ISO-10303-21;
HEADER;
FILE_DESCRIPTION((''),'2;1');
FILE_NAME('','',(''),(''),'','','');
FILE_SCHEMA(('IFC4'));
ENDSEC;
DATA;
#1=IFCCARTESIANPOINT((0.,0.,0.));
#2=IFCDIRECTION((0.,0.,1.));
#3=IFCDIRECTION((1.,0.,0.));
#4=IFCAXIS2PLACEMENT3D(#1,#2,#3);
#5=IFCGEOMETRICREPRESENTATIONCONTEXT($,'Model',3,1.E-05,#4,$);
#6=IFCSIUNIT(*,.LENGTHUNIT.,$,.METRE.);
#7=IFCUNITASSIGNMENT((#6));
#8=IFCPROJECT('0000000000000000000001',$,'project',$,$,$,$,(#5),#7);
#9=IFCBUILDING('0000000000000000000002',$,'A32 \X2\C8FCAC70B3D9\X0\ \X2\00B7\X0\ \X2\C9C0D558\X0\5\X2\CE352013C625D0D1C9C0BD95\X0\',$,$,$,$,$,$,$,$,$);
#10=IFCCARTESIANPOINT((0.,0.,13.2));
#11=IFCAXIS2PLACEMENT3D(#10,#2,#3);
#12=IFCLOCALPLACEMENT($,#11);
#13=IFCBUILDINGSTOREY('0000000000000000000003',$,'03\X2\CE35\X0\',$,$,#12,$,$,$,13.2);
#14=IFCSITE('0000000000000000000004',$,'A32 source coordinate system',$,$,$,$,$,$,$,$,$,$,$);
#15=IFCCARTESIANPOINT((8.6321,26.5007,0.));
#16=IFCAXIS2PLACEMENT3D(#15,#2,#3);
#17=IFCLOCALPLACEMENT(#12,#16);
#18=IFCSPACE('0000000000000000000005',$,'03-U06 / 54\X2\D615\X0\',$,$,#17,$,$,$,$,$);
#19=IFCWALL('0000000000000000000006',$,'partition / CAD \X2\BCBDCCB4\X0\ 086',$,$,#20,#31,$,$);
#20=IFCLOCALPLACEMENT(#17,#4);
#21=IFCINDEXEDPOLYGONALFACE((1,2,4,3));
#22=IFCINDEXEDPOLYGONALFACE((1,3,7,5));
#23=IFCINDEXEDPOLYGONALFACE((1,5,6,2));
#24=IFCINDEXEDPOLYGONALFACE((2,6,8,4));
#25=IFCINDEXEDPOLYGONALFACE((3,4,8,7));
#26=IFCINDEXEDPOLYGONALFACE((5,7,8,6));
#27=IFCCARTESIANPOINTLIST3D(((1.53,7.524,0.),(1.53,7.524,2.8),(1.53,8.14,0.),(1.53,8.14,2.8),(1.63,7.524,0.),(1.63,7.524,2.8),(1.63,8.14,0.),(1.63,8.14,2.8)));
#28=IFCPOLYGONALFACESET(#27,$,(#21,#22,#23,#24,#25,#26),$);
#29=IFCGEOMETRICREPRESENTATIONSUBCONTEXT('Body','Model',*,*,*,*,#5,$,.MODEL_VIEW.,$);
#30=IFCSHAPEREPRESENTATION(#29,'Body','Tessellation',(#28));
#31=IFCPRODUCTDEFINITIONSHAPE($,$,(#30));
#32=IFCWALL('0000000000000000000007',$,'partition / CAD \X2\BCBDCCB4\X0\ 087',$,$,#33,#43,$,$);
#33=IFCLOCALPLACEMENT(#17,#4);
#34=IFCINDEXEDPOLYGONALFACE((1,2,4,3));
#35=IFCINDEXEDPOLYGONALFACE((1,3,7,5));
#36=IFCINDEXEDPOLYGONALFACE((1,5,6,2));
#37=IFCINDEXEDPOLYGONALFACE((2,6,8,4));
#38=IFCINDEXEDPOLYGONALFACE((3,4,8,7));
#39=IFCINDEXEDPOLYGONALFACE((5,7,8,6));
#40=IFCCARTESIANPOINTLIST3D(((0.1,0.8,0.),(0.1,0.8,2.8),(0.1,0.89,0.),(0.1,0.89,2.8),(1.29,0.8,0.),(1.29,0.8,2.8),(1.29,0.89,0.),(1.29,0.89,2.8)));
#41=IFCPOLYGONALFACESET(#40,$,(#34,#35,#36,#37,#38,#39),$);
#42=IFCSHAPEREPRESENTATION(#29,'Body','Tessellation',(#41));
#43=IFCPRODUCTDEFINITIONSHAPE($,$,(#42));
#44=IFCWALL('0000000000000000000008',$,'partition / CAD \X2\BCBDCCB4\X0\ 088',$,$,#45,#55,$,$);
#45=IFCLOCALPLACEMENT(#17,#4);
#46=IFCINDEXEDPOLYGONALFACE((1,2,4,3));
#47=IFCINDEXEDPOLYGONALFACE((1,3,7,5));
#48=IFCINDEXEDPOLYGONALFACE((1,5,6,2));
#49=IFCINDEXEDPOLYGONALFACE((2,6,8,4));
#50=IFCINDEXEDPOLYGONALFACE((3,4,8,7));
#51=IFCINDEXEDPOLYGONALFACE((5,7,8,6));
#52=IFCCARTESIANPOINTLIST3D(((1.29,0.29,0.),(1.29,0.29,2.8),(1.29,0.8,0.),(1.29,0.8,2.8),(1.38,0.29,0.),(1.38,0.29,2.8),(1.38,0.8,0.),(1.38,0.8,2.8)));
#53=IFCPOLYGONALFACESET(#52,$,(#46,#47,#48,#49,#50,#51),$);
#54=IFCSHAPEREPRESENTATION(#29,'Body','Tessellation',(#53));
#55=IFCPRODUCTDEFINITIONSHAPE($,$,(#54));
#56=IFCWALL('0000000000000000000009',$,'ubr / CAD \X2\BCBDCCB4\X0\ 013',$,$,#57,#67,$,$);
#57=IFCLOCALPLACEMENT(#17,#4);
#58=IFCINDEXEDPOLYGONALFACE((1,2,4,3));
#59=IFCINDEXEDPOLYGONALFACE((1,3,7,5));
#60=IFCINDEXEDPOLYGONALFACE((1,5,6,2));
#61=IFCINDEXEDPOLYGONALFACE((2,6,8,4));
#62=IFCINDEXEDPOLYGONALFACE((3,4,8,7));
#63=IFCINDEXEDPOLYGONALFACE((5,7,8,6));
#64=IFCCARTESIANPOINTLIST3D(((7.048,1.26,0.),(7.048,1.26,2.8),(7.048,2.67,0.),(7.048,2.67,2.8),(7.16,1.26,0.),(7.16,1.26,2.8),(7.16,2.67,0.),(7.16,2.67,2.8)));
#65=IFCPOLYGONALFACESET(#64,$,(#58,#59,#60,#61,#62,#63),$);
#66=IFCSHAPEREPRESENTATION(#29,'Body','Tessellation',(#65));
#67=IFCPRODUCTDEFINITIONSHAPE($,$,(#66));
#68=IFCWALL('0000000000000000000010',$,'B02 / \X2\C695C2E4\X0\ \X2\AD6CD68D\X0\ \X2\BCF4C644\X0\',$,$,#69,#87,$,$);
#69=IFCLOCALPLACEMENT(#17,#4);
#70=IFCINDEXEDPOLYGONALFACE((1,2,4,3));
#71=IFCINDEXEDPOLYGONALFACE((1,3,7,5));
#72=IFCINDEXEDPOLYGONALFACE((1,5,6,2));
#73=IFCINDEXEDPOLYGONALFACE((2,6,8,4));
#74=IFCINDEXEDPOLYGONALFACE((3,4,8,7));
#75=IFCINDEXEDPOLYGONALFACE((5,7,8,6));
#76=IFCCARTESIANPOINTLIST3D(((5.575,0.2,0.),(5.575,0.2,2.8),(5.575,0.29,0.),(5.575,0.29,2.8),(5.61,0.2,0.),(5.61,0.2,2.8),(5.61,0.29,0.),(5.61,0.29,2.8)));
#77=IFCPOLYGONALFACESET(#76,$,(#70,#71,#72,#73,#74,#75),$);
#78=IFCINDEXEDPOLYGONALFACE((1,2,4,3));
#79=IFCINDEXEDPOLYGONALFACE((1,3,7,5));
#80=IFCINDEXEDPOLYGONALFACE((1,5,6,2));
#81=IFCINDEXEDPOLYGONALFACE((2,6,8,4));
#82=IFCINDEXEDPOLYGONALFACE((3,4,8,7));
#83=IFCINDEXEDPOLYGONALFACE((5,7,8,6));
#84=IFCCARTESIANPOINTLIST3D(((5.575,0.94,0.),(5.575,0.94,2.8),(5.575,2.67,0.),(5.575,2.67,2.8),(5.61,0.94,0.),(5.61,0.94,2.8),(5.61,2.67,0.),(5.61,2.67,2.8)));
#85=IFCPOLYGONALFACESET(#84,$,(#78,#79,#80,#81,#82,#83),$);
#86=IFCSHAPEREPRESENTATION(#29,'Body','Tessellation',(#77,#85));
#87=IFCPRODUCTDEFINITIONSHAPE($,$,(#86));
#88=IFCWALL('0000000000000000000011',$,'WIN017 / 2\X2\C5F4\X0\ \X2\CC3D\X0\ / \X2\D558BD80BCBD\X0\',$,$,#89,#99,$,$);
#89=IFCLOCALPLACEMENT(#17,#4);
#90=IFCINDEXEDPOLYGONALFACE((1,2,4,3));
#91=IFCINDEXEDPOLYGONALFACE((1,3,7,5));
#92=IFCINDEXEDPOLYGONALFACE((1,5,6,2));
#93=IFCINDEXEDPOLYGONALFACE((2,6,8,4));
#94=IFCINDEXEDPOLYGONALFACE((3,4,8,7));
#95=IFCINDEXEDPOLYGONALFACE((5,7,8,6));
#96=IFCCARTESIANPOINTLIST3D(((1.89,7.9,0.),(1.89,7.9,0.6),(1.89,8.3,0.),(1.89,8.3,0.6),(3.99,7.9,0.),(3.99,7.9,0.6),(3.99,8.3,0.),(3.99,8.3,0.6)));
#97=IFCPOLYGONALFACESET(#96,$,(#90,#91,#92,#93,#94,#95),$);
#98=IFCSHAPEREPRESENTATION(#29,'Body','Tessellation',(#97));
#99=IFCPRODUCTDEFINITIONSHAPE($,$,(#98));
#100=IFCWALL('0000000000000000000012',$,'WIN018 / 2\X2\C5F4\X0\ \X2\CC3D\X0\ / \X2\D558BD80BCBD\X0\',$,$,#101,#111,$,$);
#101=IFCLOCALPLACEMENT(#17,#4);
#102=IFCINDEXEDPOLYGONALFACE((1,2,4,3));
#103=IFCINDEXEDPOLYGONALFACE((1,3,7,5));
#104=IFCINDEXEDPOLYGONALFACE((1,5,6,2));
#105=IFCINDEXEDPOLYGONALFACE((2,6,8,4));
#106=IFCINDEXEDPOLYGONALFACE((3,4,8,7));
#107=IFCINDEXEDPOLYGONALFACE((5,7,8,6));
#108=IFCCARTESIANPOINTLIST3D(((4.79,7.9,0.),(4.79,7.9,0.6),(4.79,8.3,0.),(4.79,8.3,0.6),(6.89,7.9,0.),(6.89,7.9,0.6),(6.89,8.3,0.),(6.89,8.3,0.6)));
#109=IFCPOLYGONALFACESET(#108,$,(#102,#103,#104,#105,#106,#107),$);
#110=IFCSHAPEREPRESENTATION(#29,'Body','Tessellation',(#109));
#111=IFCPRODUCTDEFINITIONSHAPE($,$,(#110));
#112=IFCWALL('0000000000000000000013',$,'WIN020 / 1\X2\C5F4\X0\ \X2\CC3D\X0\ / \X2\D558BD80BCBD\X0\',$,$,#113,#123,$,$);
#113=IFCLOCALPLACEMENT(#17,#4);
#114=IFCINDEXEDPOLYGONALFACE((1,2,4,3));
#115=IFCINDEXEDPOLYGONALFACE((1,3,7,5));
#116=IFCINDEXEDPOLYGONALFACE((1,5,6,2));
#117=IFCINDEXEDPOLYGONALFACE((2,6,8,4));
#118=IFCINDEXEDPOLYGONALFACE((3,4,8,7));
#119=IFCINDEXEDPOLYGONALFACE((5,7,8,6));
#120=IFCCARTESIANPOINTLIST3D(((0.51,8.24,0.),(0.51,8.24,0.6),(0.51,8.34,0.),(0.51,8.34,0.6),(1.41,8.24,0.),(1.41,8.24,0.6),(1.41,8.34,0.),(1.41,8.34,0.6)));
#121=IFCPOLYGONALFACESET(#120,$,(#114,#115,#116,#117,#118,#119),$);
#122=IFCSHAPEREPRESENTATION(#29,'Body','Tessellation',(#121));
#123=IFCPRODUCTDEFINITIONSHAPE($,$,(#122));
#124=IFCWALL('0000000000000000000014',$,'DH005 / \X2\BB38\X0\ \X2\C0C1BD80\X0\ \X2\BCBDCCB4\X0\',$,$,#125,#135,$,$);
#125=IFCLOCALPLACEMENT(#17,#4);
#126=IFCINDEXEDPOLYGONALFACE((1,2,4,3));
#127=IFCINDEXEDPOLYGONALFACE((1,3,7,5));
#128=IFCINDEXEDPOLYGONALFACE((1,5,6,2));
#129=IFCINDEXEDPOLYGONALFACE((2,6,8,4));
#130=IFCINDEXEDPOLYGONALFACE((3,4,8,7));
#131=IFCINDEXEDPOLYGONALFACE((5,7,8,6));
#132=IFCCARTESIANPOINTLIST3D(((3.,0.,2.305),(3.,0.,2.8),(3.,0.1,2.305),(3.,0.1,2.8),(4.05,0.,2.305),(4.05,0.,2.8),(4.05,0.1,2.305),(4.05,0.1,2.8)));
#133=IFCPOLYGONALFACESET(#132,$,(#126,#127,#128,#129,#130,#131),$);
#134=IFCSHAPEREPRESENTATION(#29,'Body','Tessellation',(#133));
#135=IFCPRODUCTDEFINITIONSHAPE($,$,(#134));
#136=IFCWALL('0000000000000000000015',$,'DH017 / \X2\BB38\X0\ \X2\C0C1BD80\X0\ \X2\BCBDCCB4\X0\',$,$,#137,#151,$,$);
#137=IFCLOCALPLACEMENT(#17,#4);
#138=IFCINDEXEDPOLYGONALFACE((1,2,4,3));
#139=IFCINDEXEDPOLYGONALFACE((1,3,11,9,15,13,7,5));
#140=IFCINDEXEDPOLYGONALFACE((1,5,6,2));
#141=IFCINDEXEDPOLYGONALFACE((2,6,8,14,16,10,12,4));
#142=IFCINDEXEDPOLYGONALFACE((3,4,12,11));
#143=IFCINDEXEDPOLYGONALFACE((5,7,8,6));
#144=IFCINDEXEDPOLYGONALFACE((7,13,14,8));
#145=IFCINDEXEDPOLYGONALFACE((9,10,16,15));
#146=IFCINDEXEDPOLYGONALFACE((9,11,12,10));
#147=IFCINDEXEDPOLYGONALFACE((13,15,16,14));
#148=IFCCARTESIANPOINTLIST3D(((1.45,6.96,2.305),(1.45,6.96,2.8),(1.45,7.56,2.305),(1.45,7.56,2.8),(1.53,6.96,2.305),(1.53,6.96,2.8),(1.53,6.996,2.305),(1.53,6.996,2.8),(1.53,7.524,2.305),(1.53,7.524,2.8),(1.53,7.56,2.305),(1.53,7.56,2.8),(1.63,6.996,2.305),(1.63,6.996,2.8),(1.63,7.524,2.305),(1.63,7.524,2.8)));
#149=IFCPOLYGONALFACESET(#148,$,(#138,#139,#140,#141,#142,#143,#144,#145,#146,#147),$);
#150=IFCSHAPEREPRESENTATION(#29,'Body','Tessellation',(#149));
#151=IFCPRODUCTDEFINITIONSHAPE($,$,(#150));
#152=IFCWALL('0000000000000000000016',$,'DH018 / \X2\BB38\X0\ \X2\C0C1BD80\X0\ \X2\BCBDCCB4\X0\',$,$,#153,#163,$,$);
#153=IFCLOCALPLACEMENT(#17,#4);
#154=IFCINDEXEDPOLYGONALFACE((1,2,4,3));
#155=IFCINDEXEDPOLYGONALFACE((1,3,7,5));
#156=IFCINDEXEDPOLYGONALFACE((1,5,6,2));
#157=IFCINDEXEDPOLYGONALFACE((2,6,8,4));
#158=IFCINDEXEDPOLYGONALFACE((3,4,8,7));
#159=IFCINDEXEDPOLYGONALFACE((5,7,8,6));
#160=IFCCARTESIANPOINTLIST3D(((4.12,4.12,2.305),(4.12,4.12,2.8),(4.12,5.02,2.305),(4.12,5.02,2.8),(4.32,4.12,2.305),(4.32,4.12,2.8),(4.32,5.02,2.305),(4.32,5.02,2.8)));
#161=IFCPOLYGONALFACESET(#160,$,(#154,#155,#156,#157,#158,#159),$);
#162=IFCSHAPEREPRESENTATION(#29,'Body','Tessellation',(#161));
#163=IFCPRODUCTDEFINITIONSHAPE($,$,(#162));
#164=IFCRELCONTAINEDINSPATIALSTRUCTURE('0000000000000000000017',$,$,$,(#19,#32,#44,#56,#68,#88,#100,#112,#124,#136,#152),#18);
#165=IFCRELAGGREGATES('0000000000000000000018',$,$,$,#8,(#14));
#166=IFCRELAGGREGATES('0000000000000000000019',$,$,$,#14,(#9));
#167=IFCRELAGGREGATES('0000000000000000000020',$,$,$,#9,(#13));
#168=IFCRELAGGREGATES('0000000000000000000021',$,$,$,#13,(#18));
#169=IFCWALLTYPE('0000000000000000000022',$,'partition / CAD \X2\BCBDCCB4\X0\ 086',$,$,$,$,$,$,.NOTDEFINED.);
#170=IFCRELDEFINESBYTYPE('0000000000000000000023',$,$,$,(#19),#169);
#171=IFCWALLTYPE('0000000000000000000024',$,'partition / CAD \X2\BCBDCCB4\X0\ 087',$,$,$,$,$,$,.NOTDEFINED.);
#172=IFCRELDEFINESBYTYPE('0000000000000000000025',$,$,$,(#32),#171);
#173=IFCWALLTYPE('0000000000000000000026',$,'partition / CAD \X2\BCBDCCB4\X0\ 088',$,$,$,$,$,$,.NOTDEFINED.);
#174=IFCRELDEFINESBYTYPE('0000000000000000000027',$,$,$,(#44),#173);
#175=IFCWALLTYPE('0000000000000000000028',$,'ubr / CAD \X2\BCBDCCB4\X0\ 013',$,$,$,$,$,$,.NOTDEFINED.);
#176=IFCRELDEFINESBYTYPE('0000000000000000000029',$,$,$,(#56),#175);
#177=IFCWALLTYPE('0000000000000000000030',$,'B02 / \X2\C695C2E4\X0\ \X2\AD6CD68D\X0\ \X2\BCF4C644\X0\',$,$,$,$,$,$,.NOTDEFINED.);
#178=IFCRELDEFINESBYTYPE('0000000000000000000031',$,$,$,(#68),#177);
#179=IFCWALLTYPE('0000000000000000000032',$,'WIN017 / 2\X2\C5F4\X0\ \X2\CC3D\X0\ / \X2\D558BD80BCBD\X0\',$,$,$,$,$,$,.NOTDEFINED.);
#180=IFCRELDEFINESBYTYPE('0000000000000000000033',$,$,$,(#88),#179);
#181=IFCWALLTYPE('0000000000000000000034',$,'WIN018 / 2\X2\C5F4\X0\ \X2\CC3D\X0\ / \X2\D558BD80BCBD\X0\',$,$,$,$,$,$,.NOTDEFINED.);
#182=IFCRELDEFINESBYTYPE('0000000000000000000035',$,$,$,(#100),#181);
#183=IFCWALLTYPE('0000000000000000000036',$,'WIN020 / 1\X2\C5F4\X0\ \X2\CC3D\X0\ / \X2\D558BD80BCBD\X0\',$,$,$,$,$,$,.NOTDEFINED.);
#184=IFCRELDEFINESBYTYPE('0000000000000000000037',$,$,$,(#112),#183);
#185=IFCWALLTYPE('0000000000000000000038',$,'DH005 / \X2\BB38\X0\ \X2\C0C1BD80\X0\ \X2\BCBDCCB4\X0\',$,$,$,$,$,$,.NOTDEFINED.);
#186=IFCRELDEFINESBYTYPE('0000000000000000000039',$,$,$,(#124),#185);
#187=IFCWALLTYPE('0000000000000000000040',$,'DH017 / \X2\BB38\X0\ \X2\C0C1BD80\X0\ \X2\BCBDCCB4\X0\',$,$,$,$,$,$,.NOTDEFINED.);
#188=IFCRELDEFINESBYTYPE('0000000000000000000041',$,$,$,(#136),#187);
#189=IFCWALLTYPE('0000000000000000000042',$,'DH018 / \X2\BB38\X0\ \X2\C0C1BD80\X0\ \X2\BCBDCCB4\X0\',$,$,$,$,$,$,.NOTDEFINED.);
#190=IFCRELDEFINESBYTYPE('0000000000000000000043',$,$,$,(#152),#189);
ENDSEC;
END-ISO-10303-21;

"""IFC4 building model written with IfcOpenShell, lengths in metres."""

from ifc_helpers import new_model, si_unit, frame, origin, origin_with_axes, place, context, subcontext, project, spatial, polyline, outline, extrude, source, transform, mapped, type_object, type_shapes, element, save


model = new_model("IFC4")

# Units and contexts
model_context = context("Model", 3, precision=1e-05, world=origin_with_axes())
body_context = subcontext(model_context, "Body", "Model", "MODEL_VIEW")
ifc_project = project(units=[si_unit("LENGTHUNIT", "METRE")], contexts=[model_context])

# Site, building, storey, space
site = spatial("IfcSite", under=ifc_project, Name="A32 source coordinate system")
building = spatial("IfcBuilding", under=site, Name="A32 주거동 · 지하5층–옥탑지붕")
storey_placement = place(None, frame((0.0, 0.0, 13.2), z_axis=(0.0, 0.0, 1.0), x_axis=(1.0, 0.0, 0.0)))
storey = spatial("IfcBuildingStorey", under=building, at=storey_placement, Name="03층", Elevation=13.2)
space_placement = place(storey_placement, frame((8.6321, 26.5007, 0.0), z_axis=(0.0, 0.0, 1.0), x_axis=(1.0, 0.0, 0.0)))
space = spatial("IfcSpace", under=storey, at=space_placement, Name="03-U06 / 54형")

# Walls
wall_type_1 = type_object("IfcWallType", Name="partition / CAD 벽체 086", PredefinedType="NOTDEFINED")
shared_shape_1 = source(origin(), body_context, "Body", "SweptSolid", [
    extrude(outline(polyline([(1.53, 7.524), (1.53, 8.14), (1.63, 8.14), (1.63, 7.524), (1.53, 7.524)])), origin(), (0.0, 0.0, 1.0), 2.8),
])
type_shapes(wall_type_1, [shared_shape_1])
wall_1_placement = place(space_placement, origin_with_axes())
element("IfcWall", 1, at=wall_1_placement, inside=space, type_object=wall_type_1, Name="partition / CAD 벽체 086", context=body_context, shape_type="MappedRepresentation", body=[
    mapped(shared_shape_1, transform((0.0, 0.0, 0.0), scale=1.0)),
])
wall_type_2 = type_object("IfcWallType", Name="partition / CAD 벽체 087", PredefinedType="NOTDEFINED")
shared_shape_2 = source(origin(), body_context, "Body", "SweptSolid", [
    extrude(outline(polyline([(1.29, 0.8), (0.1, 0.8), (0.1, 0.89), (1.29, 0.89), (1.29, 0.8)])), origin(), (0.0, 0.0, 1.0), 2.8),
])
type_shapes(wall_type_2, [shared_shape_2])
wall_2_placement = place(space_placement, origin_with_axes())
element("IfcWall", 2, at=wall_2_placement, inside=space, type_object=wall_type_2, Name="partition / CAD 벽체 087", context=body_context, shape_type="MappedRepresentation", body=[
    mapped(shared_shape_2, transform((0.0, 0.0, 0.0), scale=1.0)),
])
wall_type_3 = type_object("IfcWallType", Name="partition / CAD 벽체 088", PredefinedType="NOTDEFINED")
shared_shape_3 = source(origin(), body_context, "Body", "SweptSolid", [
    extrude(outline(polyline([(1.29, 0.29), (1.29, 0.8), (1.38, 0.8), (1.38, 0.29), (1.29, 0.29)])), origin(), (0.0, 0.0, 1.0), 2.8),
])
type_shapes(wall_type_3, [shared_shape_3])
wall_3_placement = place(space_placement, origin_with_axes())
element("IfcWall", 3, at=wall_3_placement, inside=space, type_object=wall_type_3, Name="partition / CAD 벽체 088", context=body_context, shape_type="MappedRepresentation", body=[
    mapped(shared_shape_3, transform((0.0, 0.0, 0.0), scale=1.0)),
])
wall_type_4 = type_object("IfcWallType", Name="ubr / CAD 벽체 013", PredefinedType="NOTDEFINED")
shared_shape_4 = source(origin(), body_context, "Body", "SweptSolid", [
    extrude(outline(polyline([(7.16, 1.26), (7.048, 1.26), (7.048, 2.67), (7.16, 2.67), (7.16, 1.26)])), origin(), (0.0, 0.0, 1.0), 2.8),
])
type_shapes(wall_type_4, [shared_shape_4])
wall_4_placement = place(space_placement, origin_with_axes())
element("IfcWall", 4, at=wall_4_placement, inside=space, type_object=wall_type_4, Name="ubr / CAD 벽체 013", context=body_context, shape_type="MappedRepresentation", body=[
    mapped(shared_shape_4, transform((0.0, 0.0, 0.0), scale=1.0)),
])
wall_type_5 = type_object("IfcWallType", Name="B02 / 욕실 구획 보완", PredefinedType="NOTDEFINED")
shared_shape_5 = source(origin(), body_context, "Body", "SweptSolid", [
    extrude(outline(polyline([(5.575, 0.2), (5.575, 0.29), (5.61, 0.29), (5.61, 0.2), (5.575, 0.2)])), origin(), (0.0, 0.0, 1.0), 2.8),
    extrude(outline(polyline([(5.575, 0.94), (5.575, 2.67), (5.61, 2.67), (5.61, 0.94), (5.575, 0.94)])), origin(), (0.0, 0.0, 1.0), 2.8),
])
type_shapes(wall_type_5, [shared_shape_5])
wall_5_placement = place(space_placement, origin_with_axes())
element("IfcWall", 5, at=wall_5_placement, inside=space, type_object=wall_type_5, Name="B02 / 욕실 구획 보완", context=body_context, shape_type="MappedRepresentation", body=[
    mapped(shared_shape_5, transform((0.0, 0.0, 0.0), scale=1.0)),
])
wall_type_6 = type_object("IfcWallType", Name="WIN017 / 2열 창 / 하부벽", PredefinedType="NOTDEFINED")
shared_shape_6 = source(origin(), body_context, "Body", "SweptSolid", [
    extrude(outline(polyline([(3.99, 8.3), (3.99, 7.9), (1.89, 7.9), (1.89, 8.3), (3.99, 8.3)])), origin(), (0.0, 0.0, 1.0), 0.6),
])
type_shapes(wall_type_6, [shared_shape_6])
wall_6_placement = place(space_placement, origin_with_axes())
element("IfcWall", 6, at=wall_6_placement, inside=space, type_object=wall_type_6, Name="WIN017 / 2열 창 / 하부벽", context=body_context, shape_type="MappedRepresentation", body=[
    mapped(shared_shape_6, transform((0.0, 0.0, 0.0), scale=1.0)),
])
wall_type_7 = type_object("IfcWallType", Name="WIN018 / 2열 창 / 하부벽", PredefinedType="NOTDEFINED")
shared_shape_7 = source(origin(), body_context, "Body", "SweptSolid", [
    extrude(outline(polyline([(6.89, 8.3), (6.89, 7.9), (4.79, 7.9), (4.79, 8.3), (6.89, 8.3)])), origin(), (0.0, 0.0, 1.0), 0.6),
])
type_shapes(wall_type_7, [shared_shape_7])
wall_7_placement = place(space_placement, origin_with_axes())
element("IfcWall", 7, at=wall_7_placement, inside=space, type_object=wall_type_7, Name="WIN018 / 2열 창 / 하부벽", context=body_context, shape_type="MappedRepresentation", body=[
    mapped(shared_shape_7, transform((0.0, 0.0, 0.0), scale=1.0)),
])
wall_type_8 = type_object("IfcWallType", Name="WIN020 / 1열 창 / 하부벽", PredefinedType="NOTDEFINED")
shared_shape_8 = source(origin(), body_context, "Body", "SweptSolid", [
    extrude(outline(polyline([(1.41, 8.34), (1.41, 8.24), (0.51, 8.24), (0.51, 8.34), (1.41, 8.34)])), origin(), (0.0, 0.0, 1.0), 0.6),
])
type_shapes(wall_type_8, [shared_shape_8])
wall_8_placement = place(space_placement, origin_with_axes())
element("IfcWall", 8, at=wall_8_placement, inside=space, type_object=wall_type_8, Name="WIN020 / 1열 창 / 하부벽", context=body_context, shape_type="MappedRepresentation", body=[
    mapped(shared_shape_8, transform((0.0, 0.0, 0.0), scale=1.0)),
])
wall_type_9 = type_object("IfcWallType", Name="DH005 / 문 상부 벽체", PredefinedType="NOTDEFINED")
shared_shape_9 = source(origin(), body_context, "Body", "SweptSolid", [
    extrude(outline(polyline([(4.05, 0.0), (3.0, 0.0), (3.0, 0.1), (4.05, 0.1), (4.05, 0.0)])), frame((0.0, 0.0, 2.305)), (0.0, 0.0, 1.0), 0.495),
])
type_shapes(wall_type_9, [shared_shape_9])
wall_9_placement = place(space_placement, origin_with_axes())
element("IfcWall", 9, at=wall_9_placement, inside=space, type_object=wall_type_9, Name="DH005 / 문 상부 벽체", context=body_context, shape_type="MappedRepresentation", body=[
    mapped(shared_shape_9, transform((0.0, 0.0, 0.0), scale=1.0)),
])
wall_type_10 = type_object("IfcWallType", Name="DH017 / 문 상부 벽체", PredefinedType="NOTDEFINED")
shared_shape_10 = source(origin(), body_context, "Body", "SweptSolid", [
    extrude(outline(polyline([(1.63, 7.524), (1.63, 6.996), (1.53, 6.996), (1.53, 6.96), (1.45, 6.96), (1.45, 7.56), (1.53, 7.56), (1.53, 7.524), (1.63, 7.524)])), frame((0.0, 0.0, 2.305)), (0.0, 0.0, 1.0), 0.495),
])
type_shapes(wall_type_10, [shared_shape_10])
wall_10_placement = place(space_placement, origin_with_axes())
element("IfcWall", 10, at=wall_10_placement, inside=space, type_object=wall_type_10, Name="DH017 / 문 상부 벽체", context=body_context, shape_type="MappedRepresentation", body=[
    mapped(shared_shape_10, transform((0.0, 0.0, 0.0), scale=1.0)),
])
wall_type_11 = type_object("IfcWallType", Name="DH018 / 문 상부 벽체", PredefinedType="NOTDEFINED")
shared_shape_11 = source(origin(), body_context, "Body", "SweptSolid", [
    extrude(outline(polyline([(4.32, 4.12), (4.12, 4.12), (4.12, 5.02), (4.32, 5.02), (4.32, 4.12)])), frame((0.0, 0.0, 2.305)), (0.0, 0.0, 1.0), 0.495),
])
type_shapes(wall_type_11, [shared_shape_11])
wall_11_placement = place(space_placement, origin_with_axes())
element("IfcWall", 11, at=wall_11_placement, inside=space, type_object=wall_type_11, Name="DH018 / 문 상부 벽체", context=body_context, shape_type="MappedRepresentation", body=[
    mapped(shared_shape_11, transform((0.0, 0.0, 0.0), scale=1.0)),
])

save(model, "model.ifc")
